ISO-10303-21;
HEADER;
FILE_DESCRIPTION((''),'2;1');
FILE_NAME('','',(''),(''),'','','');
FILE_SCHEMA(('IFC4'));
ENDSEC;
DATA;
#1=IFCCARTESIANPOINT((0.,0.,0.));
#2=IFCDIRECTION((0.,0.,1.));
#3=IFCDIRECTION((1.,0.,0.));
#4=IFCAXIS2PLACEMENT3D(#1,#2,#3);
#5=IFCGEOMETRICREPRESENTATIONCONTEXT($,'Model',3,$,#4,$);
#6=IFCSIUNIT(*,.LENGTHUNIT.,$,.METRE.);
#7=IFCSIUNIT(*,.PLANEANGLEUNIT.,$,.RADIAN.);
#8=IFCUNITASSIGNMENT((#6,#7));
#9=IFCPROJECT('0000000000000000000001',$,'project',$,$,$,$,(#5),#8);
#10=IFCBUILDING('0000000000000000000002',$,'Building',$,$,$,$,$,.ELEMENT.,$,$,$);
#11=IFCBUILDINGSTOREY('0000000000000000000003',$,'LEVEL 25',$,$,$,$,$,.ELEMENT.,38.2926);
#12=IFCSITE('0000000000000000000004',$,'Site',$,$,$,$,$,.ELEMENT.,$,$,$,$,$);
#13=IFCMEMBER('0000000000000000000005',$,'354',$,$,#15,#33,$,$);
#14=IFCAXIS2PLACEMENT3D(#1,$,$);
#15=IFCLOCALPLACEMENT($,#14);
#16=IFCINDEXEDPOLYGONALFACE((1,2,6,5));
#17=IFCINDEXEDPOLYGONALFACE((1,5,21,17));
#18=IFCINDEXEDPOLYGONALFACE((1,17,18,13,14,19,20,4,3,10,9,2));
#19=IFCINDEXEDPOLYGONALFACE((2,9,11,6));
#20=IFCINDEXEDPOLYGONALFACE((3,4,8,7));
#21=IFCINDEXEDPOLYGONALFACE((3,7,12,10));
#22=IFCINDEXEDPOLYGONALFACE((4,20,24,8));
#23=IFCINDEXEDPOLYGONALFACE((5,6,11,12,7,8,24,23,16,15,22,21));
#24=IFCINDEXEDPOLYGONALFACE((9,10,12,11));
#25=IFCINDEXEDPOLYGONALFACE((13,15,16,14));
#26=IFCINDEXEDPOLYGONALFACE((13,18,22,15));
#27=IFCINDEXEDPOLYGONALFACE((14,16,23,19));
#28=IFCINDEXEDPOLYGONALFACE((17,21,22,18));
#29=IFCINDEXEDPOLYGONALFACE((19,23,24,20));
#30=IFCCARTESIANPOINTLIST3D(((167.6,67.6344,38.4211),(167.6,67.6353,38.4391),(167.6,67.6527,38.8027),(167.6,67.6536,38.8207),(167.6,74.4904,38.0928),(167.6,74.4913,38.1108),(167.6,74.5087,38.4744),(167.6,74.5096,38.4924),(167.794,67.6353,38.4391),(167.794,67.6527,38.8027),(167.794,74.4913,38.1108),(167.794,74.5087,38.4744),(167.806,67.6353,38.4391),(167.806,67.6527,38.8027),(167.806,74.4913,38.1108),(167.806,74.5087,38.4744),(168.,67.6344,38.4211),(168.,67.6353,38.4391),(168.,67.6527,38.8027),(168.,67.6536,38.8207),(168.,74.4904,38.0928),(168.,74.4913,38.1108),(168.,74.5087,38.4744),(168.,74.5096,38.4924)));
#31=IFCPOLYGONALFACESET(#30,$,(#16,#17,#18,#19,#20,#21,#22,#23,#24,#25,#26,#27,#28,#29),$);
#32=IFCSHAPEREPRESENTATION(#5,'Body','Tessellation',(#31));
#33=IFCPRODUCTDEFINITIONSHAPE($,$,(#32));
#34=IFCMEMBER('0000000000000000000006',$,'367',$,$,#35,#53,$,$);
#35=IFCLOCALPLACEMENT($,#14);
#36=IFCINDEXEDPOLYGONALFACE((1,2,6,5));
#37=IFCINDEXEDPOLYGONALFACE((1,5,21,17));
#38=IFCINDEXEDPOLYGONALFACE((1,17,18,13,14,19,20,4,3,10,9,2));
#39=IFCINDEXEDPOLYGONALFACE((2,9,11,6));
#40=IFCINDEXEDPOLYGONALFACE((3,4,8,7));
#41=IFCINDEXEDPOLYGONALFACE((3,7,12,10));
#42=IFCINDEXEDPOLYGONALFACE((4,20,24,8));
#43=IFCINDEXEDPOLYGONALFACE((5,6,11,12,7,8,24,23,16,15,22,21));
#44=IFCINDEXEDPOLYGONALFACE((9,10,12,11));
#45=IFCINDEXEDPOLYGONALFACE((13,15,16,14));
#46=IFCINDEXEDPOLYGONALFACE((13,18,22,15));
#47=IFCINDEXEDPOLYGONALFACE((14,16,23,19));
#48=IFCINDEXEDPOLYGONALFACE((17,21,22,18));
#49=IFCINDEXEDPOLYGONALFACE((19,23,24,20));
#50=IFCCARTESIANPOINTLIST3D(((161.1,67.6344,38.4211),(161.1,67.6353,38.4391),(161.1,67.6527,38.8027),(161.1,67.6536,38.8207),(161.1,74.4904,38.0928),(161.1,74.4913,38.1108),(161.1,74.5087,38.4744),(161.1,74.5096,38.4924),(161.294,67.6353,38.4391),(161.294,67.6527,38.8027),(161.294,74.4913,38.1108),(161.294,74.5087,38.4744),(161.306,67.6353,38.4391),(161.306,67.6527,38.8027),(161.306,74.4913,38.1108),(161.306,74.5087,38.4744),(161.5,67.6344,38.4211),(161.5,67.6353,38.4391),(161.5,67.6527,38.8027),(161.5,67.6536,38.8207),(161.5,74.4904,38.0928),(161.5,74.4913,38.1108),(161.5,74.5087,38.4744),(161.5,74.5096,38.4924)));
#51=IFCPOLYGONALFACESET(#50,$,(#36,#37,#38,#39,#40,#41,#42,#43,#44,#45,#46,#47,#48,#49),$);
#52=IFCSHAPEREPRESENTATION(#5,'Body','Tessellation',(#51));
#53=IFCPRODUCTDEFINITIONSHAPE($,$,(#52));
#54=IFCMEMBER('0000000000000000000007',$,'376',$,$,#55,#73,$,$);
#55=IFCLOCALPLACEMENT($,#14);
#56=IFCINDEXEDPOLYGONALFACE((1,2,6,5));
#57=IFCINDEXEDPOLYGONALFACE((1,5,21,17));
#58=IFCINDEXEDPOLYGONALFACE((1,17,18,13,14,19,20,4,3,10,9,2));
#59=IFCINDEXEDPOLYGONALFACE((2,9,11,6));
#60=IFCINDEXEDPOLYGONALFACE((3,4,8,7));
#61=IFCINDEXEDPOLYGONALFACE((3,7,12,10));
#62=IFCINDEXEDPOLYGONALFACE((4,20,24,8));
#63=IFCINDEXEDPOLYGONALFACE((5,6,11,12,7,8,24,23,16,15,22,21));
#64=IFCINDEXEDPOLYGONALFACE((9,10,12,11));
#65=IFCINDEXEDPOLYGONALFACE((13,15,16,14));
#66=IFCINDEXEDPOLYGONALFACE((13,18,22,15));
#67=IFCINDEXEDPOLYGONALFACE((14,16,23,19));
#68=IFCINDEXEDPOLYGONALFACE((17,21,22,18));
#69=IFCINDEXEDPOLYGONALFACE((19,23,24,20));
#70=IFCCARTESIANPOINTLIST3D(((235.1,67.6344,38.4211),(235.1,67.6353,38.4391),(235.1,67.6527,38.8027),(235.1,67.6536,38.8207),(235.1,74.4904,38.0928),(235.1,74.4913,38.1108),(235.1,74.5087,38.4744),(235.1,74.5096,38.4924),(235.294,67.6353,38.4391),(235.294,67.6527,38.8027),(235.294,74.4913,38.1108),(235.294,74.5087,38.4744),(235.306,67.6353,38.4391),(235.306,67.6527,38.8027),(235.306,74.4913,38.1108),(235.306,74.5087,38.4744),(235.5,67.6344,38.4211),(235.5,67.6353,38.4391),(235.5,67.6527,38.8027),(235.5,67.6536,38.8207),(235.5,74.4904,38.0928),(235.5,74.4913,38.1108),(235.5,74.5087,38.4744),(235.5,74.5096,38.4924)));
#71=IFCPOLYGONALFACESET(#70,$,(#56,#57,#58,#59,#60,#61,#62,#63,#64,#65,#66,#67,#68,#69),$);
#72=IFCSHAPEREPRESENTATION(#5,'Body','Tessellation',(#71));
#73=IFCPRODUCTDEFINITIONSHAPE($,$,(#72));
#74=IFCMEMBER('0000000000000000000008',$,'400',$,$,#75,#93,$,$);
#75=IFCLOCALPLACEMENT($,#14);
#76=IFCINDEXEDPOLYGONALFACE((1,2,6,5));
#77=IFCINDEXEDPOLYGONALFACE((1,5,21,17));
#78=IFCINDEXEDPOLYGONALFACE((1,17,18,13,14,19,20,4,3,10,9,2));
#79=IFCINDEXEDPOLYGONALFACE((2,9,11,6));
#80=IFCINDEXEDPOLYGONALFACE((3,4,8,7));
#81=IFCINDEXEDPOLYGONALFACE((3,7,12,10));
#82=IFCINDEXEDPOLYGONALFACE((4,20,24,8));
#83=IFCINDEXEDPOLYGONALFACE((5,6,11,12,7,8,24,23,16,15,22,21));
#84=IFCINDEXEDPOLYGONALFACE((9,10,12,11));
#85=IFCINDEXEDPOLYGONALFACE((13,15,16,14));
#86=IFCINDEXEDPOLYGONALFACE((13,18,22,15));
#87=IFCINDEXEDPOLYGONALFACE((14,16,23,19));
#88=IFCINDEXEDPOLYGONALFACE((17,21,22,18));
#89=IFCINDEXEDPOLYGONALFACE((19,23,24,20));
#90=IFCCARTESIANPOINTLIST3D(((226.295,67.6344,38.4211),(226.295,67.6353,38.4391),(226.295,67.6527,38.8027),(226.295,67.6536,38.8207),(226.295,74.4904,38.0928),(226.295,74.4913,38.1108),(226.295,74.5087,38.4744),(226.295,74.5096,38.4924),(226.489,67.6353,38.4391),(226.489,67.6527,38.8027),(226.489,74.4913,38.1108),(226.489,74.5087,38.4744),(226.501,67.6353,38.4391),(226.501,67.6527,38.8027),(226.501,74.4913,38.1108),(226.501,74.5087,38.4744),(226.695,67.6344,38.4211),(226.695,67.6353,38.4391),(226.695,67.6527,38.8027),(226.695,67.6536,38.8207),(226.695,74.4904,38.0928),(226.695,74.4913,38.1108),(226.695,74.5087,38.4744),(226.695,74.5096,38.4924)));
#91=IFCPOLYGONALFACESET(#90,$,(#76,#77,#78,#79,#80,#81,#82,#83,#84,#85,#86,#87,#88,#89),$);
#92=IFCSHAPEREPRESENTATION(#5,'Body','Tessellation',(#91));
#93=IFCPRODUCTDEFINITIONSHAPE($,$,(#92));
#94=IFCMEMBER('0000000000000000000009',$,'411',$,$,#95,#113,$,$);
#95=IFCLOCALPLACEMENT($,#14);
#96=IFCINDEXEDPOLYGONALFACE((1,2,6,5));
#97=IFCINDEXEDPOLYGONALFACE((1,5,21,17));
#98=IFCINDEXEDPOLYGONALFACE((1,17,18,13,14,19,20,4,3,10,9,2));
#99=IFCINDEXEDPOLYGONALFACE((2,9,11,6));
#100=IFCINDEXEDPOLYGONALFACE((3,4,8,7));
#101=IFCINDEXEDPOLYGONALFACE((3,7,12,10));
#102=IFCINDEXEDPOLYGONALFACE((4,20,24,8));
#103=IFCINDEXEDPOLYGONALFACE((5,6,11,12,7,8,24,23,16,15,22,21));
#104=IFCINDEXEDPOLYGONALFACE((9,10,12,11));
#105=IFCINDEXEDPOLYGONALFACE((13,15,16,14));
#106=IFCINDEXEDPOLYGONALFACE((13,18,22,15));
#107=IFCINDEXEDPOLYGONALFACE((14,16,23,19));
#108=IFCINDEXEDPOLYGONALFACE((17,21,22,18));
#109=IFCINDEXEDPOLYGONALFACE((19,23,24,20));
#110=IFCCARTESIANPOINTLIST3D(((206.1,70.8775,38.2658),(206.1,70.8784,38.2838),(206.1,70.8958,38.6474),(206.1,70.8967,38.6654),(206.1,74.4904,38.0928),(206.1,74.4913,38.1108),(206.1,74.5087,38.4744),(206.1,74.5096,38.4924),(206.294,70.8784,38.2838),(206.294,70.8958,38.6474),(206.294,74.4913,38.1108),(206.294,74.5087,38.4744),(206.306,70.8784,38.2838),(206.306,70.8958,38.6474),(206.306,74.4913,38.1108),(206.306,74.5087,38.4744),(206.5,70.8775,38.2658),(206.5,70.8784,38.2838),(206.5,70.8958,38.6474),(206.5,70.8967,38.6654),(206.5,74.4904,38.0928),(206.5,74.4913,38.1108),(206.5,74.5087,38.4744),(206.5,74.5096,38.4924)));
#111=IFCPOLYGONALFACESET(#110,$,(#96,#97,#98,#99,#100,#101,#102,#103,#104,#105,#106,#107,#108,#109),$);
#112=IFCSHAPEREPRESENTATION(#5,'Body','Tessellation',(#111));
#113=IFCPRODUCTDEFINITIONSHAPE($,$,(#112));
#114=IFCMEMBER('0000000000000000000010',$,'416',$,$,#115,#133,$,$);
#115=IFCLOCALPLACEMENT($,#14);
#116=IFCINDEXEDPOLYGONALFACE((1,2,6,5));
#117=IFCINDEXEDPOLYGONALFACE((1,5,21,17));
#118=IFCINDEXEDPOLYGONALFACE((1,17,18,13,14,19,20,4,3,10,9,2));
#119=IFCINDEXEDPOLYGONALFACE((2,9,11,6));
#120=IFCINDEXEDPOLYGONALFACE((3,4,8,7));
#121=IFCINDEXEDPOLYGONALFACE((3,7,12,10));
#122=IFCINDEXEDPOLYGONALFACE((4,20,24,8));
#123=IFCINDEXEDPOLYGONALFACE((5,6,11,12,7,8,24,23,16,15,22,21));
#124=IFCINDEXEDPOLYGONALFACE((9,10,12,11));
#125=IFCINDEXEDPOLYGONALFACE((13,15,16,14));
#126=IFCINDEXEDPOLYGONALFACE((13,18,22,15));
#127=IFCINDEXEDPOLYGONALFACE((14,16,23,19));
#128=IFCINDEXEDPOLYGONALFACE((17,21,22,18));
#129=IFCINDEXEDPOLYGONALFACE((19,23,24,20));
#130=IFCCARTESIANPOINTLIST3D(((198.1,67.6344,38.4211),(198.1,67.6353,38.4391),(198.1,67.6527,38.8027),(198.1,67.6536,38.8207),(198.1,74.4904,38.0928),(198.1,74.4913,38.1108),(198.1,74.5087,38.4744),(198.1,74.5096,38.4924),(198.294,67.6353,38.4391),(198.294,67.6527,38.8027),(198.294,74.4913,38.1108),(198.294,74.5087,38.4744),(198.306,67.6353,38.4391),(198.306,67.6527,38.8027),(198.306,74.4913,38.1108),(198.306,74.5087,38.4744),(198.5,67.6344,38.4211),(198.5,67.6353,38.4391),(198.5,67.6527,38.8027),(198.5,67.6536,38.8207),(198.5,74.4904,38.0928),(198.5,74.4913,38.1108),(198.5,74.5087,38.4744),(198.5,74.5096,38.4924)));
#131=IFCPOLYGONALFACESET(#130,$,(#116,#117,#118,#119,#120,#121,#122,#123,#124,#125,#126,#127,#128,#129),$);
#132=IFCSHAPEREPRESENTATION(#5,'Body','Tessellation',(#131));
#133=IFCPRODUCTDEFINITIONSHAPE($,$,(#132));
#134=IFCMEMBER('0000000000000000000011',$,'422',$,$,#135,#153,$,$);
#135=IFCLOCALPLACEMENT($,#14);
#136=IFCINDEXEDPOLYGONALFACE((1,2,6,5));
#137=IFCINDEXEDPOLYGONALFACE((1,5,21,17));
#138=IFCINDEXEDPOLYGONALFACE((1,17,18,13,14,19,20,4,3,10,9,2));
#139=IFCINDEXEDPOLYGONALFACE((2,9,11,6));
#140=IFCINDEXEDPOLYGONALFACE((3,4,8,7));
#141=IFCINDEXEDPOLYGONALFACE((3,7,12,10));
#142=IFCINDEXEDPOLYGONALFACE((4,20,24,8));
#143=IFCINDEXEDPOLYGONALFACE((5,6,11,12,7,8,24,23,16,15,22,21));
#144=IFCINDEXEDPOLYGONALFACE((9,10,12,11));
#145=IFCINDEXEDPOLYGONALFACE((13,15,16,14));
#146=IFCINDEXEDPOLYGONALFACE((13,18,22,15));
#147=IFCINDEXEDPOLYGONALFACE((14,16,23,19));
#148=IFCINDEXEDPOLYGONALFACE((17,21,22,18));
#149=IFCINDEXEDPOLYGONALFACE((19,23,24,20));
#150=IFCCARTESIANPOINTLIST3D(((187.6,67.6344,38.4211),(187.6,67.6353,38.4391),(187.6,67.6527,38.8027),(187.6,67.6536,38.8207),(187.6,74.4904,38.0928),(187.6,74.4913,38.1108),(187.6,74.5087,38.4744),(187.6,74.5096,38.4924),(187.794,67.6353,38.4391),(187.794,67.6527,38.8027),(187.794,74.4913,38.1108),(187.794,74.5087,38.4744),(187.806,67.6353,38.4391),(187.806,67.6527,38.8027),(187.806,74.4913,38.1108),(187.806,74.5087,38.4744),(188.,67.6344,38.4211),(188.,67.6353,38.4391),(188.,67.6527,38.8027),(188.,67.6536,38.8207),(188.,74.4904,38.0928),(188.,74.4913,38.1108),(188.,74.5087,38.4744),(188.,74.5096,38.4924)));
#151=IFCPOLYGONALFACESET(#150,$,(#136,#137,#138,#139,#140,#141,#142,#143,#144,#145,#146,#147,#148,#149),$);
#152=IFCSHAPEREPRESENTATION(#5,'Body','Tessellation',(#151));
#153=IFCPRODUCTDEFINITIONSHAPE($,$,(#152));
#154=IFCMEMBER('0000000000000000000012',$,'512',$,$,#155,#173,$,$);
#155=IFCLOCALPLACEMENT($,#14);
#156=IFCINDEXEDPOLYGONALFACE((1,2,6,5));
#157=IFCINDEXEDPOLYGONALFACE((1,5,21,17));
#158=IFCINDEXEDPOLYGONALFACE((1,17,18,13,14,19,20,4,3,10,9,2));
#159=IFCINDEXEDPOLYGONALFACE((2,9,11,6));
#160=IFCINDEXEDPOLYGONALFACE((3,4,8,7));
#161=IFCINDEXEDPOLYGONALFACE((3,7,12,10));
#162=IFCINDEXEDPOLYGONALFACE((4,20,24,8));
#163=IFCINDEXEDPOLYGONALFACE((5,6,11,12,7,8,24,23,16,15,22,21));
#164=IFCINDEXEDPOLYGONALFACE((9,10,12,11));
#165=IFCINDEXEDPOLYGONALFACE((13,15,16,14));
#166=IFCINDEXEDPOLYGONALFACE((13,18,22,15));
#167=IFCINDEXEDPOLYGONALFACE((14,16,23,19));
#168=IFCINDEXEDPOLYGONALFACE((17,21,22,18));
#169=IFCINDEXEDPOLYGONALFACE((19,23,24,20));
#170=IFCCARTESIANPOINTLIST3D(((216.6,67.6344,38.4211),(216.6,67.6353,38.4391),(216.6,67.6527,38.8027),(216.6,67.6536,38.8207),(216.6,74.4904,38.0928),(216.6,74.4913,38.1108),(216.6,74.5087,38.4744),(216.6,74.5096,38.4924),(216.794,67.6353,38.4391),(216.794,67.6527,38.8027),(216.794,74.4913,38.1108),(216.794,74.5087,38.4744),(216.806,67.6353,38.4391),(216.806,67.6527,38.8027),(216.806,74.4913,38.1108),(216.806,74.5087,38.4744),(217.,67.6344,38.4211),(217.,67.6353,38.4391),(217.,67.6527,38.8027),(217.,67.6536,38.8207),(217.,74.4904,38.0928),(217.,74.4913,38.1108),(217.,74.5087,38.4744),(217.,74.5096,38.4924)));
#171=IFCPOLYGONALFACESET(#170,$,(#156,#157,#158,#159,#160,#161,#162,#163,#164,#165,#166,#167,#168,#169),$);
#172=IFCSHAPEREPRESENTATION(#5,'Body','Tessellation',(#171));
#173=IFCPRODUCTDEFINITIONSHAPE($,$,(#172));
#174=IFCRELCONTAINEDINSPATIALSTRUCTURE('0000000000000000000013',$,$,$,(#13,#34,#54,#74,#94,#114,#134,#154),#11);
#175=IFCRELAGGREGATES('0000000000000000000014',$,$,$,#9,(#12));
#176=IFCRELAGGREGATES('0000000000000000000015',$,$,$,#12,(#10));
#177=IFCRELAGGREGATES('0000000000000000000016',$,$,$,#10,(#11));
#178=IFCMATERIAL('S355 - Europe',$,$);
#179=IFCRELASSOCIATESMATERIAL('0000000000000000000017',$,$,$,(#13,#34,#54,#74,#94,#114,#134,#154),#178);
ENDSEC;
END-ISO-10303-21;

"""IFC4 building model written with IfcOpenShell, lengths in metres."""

from ifc_helpers import new_model, si_unit, frame, origin_with_axes, origin_2d_with_axis, place, context, project, spatial, i_section, extrude, material, material_profile, profile_set, profile_usage, element, save


model = new_model("IFC4")

# Units and contexts
model_context = context("Model", 3, world=origin_with_axes())
ifc_project = project(units=[si_unit("LENGTHUNIT", "METRE"), si_unit("PLANEANGLEUNIT", "RADIAN")], contexts=[model_context])

# Site, building, storey
site = spatial("IfcSite", under=ifc_project, Name="Site", CompositionType="ELEMENT")
building = spatial("IfcBuilding", under=site, Name="Building", CompositionType="ELEMENT")
storey = spatial("IfcBuildingStorey", under=building, Name="LEVEL 25", CompositionType="ELEMENT", Elevation=38.2926)

# Shared definitions
ifc_material = material(Name="S355 - Europe")

# Members
ifc_material_profile_1 = material_profile(ifc_material, i_section(OverallWidth=0.4, OverallDepth=0.4, WebThickness=0.012, FlangeThickness=0.018, at=origin_2d_with_axis()))
ifc_profile_set_1 = profile_set([ifc_material_profile_1])
ifc_profile_usage_1 = profile_usage(ifc_profile_set_1, cardinal=10)
member_1_placement = place(None, frame((167.8, 74.5, 38.2926), z_axis=(0.0, -0.998856, 0.047828), x_axis=(1.0, 0.0, 0.0)))
element("IfcMember", 1, at=member_1_placement, inside=storey, material=ifc_profile_usage_1, Name="354", context=model_context, shape_type="SweptSolid", body=[
    extrude(i_section(OverallWidth=0.4, OverallDepth=0.4, WebThickness=0.012, FlangeThickness=0.018, at=origin_2d_with_axis()), origin_with_axes(), (0.0, 0.0, 1.0), 6.8639),
])
ifc_material_profile_2 = material_profile(ifc_material, i_section(OverallWidth=0.4, OverallDepth=0.4, WebThickness=0.012, FlangeThickness=0.018, at=origin_2d_with_axis()))
ifc_profile_set_2 = profile_set([ifc_material_profile_2])
ifc_profile_usage_2 = profile_usage(ifc_profile_set_2, cardinal=10)
member_2_placement = place(None, frame((161.3, 74.5, 38.2926), z_axis=(0.0, -0.998856, 0.047828), x_axis=(1.0, 0.0, 0.0)))
element("IfcMember", 2, at=member_2_placement, inside=storey, material=ifc_profile_usage_2, Name="367", context=model_context, shape_type="SweptSolid", body=[
    extrude(i_section(OverallWidth=0.4, OverallDepth=0.4, WebThickness=0.012, FlangeThickness=0.018, at=origin_2d_with_axis()), origin_with_axes(), (0.0, 0.0, 1.0), 6.8639),
])
ifc_material_profile_3 = material_profile(ifc_material, i_section(OverallWidth=0.4, OverallDepth=0.4, WebThickness=0.012, FlangeThickness=0.018, at=origin_2d_with_axis()))
ifc_profile_set_3 = profile_set([ifc_material_profile_3])
ifc_profile_usage_3 = profile_usage(ifc_profile_set_3, cardinal=10)
member_3_placement = place(None, frame((235.3, 74.5, 38.2926), z_axis=(0.0, -0.998856, 0.047828), x_axis=(1.0, 0.0, 0.0)))
element("IfcMember", 3, at=member_3_placement, inside=storey, material=ifc_profile_usage_3, Name="376", context=model_context, shape_type="SweptSolid", body=[
    extrude(i_section(OverallWidth=0.4, OverallDepth=0.4, WebThickness=0.012, FlangeThickness=0.018, at=origin_2d_with_axis()), origin_with_axes(), (0.0, 0.0, 1.0), 6.8639),
])
ifc_material_profile_4 = material_profile(ifc_material, i_section(OverallWidth=0.4, OverallDepth=0.4, WebThickness=0.012, FlangeThickness=0.018, at=origin_2d_with_axis()))
ifc_profile_set_4 = profile_set([ifc_material_profile_4])
ifc_profile_usage_4 = profile_usage(ifc_profile_set_4, cardinal=10)
member_4_placement = place(None, frame((226.495, 74.5, 38.2926), z_axis=(0.0, -0.998856, 0.047828), x_axis=(1.0, 0.0, 0.0)))
element("IfcMember", 4, at=member_4_placement, inside=storey, material=ifc_profile_usage_4, Name="400", context=model_context, shape_type="SweptSolid", body=[
    extrude(i_section(OverallWidth=0.4, OverallDepth=0.4, WebThickness=0.012, FlangeThickness=0.018, at=origin_2d_with_axis()), origin_with_axes(), (0.0, 0.0, 1.0), 6.8639),
])
ifc_material_profile_5 = material_profile(ifc_material, i_section(OverallWidth=0.4, OverallDepth=0.4, WebThickness=0.012, FlangeThickness=0.018, at=origin_2d_with_axis()))
ifc_profile_set_5 = profile_set([ifc_material_profile_5])
ifc_profile_usage_5 = profile_usage(ifc_profile_set_5, cardinal=10)
member_5_placement = place(None, frame((206.3, 74.5, 38.2926), z_axis=(0.0, -0.998856, 0.047828), x_axis=(1.0, 0.0, 0.0)))
element("IfcMember", 5, at=member_5_placement, inside=storey, material=ifc_profile_usage_5, Name="411", context=model_context, shape_type="SweptSolid", body=[
    extrude(i_section(OverallWidth=0.4, OverallDepth=0.4, WebThickness=0.012, FlangeThickness=0.018, at=origin_2d_with_axis()), origin_with_axes(), (0.0, 0.0, 1.0), 3.617),
])
ifc_material_profile_6 = material_profile(ifc_material, i_section(OverallWidth=0.4, OverallDepth=0.4, WebThickness=0.012, FlangeThickness=0.018, at=origin_2d_with_axis()))
ifc_profile_set_6 = profile_set([ifc_material_profile_6])
ifc_profile_usage_6 = profile_usage(ifc_profile_set_6, cardinal=10)
member_6_placement = place(None, frame((198.3, 74.5, 38.2926), z_axis=(0.0, -0.998856, 0.047828), x_axis=(1.0, 0.0, 0.0)))
element("IfcMember", 6, at=member_6_placement, inside=storey, material=ifc_profile_usage_6, Name="416", context=model_context, shape_type="SweptSolid", body=[
    extrude(i_section(OverallWidth=0.4, OverallDepth=0.4, WebThickness=0.012, FlangeThickness=0.018, at=origin_2d_with_axis()), origin_with_axes(), (0.0, 0.0, 1.0), 6.8639),
])
ifc_material_profile_7 = material_profile(ifc_material, i_section(OverallWidth=0.4, OverallDepth=0.4, WebThickness=0.012, FlangeThickness=0.018, at=origin_2d_with_axis()))
ifc_profile_set_7 = profile_set([ifc_material_profile_7])
ifc_profile_usage_7 = profile_usage(ifc_profile_set_7, cardinal=10)
member_7_placement = place(None, frame((187.8, 74.5, 38.2926), z_axis=(0.0, -0.998856, 0.047828), x_axis=(1.0, 0.0, 0.0)))
element("IfcMember", 7, at=member_7_placement, inside=storey, material=ifc_profile_usage_7, Name="422", context=model_context, shape_type="SweptSolid", body=[
    extrude(i_section(OverallWidth=0.4, OverallDepth=0.4, WebThickness=0.012, FlangeThickness=0.018, at=origin_2d_with_axis()), origin_with_axes(), (0.0, 0.0, 1.0), 6.8639),
])
ifc_material_profile_8 = material_profile(ifc_material, i_section(OverallWidth=0.4, OverallDepth=0.4, WebThickness=0.012, FlangeThickness=0.018, at=origin_2d_with_axis()))
ifc_profile_set_8 = profile_set([ifc_material_profile_8])
ifc_profile_usage_8 = profile_usage(ifc_profile_set_8, cardinal=10)
member_8_placement = place(None, frame((216.8, 74.5, 38.2926), z_axis=(0.0, -0.998856, 0.047828), x_axis=(1.0, 0.0, 0.0)))
element("IfcMember", 8, at=member_8_placement, inside=storey, material=ifc_profile_usage_8, Name="512", context=model_context, shape_type="SweptSolid", body=[
    extrude(i_section(OverallWidth=0.4, OverallDepth=0.4, WebThickness=0.012, FlangeThickness=0.018, at=origin_2d_with_axis()), origin_with_axes(), (0.0, 0.0, 1.0), 6.8639),
])

save(model, "model.ifc")
